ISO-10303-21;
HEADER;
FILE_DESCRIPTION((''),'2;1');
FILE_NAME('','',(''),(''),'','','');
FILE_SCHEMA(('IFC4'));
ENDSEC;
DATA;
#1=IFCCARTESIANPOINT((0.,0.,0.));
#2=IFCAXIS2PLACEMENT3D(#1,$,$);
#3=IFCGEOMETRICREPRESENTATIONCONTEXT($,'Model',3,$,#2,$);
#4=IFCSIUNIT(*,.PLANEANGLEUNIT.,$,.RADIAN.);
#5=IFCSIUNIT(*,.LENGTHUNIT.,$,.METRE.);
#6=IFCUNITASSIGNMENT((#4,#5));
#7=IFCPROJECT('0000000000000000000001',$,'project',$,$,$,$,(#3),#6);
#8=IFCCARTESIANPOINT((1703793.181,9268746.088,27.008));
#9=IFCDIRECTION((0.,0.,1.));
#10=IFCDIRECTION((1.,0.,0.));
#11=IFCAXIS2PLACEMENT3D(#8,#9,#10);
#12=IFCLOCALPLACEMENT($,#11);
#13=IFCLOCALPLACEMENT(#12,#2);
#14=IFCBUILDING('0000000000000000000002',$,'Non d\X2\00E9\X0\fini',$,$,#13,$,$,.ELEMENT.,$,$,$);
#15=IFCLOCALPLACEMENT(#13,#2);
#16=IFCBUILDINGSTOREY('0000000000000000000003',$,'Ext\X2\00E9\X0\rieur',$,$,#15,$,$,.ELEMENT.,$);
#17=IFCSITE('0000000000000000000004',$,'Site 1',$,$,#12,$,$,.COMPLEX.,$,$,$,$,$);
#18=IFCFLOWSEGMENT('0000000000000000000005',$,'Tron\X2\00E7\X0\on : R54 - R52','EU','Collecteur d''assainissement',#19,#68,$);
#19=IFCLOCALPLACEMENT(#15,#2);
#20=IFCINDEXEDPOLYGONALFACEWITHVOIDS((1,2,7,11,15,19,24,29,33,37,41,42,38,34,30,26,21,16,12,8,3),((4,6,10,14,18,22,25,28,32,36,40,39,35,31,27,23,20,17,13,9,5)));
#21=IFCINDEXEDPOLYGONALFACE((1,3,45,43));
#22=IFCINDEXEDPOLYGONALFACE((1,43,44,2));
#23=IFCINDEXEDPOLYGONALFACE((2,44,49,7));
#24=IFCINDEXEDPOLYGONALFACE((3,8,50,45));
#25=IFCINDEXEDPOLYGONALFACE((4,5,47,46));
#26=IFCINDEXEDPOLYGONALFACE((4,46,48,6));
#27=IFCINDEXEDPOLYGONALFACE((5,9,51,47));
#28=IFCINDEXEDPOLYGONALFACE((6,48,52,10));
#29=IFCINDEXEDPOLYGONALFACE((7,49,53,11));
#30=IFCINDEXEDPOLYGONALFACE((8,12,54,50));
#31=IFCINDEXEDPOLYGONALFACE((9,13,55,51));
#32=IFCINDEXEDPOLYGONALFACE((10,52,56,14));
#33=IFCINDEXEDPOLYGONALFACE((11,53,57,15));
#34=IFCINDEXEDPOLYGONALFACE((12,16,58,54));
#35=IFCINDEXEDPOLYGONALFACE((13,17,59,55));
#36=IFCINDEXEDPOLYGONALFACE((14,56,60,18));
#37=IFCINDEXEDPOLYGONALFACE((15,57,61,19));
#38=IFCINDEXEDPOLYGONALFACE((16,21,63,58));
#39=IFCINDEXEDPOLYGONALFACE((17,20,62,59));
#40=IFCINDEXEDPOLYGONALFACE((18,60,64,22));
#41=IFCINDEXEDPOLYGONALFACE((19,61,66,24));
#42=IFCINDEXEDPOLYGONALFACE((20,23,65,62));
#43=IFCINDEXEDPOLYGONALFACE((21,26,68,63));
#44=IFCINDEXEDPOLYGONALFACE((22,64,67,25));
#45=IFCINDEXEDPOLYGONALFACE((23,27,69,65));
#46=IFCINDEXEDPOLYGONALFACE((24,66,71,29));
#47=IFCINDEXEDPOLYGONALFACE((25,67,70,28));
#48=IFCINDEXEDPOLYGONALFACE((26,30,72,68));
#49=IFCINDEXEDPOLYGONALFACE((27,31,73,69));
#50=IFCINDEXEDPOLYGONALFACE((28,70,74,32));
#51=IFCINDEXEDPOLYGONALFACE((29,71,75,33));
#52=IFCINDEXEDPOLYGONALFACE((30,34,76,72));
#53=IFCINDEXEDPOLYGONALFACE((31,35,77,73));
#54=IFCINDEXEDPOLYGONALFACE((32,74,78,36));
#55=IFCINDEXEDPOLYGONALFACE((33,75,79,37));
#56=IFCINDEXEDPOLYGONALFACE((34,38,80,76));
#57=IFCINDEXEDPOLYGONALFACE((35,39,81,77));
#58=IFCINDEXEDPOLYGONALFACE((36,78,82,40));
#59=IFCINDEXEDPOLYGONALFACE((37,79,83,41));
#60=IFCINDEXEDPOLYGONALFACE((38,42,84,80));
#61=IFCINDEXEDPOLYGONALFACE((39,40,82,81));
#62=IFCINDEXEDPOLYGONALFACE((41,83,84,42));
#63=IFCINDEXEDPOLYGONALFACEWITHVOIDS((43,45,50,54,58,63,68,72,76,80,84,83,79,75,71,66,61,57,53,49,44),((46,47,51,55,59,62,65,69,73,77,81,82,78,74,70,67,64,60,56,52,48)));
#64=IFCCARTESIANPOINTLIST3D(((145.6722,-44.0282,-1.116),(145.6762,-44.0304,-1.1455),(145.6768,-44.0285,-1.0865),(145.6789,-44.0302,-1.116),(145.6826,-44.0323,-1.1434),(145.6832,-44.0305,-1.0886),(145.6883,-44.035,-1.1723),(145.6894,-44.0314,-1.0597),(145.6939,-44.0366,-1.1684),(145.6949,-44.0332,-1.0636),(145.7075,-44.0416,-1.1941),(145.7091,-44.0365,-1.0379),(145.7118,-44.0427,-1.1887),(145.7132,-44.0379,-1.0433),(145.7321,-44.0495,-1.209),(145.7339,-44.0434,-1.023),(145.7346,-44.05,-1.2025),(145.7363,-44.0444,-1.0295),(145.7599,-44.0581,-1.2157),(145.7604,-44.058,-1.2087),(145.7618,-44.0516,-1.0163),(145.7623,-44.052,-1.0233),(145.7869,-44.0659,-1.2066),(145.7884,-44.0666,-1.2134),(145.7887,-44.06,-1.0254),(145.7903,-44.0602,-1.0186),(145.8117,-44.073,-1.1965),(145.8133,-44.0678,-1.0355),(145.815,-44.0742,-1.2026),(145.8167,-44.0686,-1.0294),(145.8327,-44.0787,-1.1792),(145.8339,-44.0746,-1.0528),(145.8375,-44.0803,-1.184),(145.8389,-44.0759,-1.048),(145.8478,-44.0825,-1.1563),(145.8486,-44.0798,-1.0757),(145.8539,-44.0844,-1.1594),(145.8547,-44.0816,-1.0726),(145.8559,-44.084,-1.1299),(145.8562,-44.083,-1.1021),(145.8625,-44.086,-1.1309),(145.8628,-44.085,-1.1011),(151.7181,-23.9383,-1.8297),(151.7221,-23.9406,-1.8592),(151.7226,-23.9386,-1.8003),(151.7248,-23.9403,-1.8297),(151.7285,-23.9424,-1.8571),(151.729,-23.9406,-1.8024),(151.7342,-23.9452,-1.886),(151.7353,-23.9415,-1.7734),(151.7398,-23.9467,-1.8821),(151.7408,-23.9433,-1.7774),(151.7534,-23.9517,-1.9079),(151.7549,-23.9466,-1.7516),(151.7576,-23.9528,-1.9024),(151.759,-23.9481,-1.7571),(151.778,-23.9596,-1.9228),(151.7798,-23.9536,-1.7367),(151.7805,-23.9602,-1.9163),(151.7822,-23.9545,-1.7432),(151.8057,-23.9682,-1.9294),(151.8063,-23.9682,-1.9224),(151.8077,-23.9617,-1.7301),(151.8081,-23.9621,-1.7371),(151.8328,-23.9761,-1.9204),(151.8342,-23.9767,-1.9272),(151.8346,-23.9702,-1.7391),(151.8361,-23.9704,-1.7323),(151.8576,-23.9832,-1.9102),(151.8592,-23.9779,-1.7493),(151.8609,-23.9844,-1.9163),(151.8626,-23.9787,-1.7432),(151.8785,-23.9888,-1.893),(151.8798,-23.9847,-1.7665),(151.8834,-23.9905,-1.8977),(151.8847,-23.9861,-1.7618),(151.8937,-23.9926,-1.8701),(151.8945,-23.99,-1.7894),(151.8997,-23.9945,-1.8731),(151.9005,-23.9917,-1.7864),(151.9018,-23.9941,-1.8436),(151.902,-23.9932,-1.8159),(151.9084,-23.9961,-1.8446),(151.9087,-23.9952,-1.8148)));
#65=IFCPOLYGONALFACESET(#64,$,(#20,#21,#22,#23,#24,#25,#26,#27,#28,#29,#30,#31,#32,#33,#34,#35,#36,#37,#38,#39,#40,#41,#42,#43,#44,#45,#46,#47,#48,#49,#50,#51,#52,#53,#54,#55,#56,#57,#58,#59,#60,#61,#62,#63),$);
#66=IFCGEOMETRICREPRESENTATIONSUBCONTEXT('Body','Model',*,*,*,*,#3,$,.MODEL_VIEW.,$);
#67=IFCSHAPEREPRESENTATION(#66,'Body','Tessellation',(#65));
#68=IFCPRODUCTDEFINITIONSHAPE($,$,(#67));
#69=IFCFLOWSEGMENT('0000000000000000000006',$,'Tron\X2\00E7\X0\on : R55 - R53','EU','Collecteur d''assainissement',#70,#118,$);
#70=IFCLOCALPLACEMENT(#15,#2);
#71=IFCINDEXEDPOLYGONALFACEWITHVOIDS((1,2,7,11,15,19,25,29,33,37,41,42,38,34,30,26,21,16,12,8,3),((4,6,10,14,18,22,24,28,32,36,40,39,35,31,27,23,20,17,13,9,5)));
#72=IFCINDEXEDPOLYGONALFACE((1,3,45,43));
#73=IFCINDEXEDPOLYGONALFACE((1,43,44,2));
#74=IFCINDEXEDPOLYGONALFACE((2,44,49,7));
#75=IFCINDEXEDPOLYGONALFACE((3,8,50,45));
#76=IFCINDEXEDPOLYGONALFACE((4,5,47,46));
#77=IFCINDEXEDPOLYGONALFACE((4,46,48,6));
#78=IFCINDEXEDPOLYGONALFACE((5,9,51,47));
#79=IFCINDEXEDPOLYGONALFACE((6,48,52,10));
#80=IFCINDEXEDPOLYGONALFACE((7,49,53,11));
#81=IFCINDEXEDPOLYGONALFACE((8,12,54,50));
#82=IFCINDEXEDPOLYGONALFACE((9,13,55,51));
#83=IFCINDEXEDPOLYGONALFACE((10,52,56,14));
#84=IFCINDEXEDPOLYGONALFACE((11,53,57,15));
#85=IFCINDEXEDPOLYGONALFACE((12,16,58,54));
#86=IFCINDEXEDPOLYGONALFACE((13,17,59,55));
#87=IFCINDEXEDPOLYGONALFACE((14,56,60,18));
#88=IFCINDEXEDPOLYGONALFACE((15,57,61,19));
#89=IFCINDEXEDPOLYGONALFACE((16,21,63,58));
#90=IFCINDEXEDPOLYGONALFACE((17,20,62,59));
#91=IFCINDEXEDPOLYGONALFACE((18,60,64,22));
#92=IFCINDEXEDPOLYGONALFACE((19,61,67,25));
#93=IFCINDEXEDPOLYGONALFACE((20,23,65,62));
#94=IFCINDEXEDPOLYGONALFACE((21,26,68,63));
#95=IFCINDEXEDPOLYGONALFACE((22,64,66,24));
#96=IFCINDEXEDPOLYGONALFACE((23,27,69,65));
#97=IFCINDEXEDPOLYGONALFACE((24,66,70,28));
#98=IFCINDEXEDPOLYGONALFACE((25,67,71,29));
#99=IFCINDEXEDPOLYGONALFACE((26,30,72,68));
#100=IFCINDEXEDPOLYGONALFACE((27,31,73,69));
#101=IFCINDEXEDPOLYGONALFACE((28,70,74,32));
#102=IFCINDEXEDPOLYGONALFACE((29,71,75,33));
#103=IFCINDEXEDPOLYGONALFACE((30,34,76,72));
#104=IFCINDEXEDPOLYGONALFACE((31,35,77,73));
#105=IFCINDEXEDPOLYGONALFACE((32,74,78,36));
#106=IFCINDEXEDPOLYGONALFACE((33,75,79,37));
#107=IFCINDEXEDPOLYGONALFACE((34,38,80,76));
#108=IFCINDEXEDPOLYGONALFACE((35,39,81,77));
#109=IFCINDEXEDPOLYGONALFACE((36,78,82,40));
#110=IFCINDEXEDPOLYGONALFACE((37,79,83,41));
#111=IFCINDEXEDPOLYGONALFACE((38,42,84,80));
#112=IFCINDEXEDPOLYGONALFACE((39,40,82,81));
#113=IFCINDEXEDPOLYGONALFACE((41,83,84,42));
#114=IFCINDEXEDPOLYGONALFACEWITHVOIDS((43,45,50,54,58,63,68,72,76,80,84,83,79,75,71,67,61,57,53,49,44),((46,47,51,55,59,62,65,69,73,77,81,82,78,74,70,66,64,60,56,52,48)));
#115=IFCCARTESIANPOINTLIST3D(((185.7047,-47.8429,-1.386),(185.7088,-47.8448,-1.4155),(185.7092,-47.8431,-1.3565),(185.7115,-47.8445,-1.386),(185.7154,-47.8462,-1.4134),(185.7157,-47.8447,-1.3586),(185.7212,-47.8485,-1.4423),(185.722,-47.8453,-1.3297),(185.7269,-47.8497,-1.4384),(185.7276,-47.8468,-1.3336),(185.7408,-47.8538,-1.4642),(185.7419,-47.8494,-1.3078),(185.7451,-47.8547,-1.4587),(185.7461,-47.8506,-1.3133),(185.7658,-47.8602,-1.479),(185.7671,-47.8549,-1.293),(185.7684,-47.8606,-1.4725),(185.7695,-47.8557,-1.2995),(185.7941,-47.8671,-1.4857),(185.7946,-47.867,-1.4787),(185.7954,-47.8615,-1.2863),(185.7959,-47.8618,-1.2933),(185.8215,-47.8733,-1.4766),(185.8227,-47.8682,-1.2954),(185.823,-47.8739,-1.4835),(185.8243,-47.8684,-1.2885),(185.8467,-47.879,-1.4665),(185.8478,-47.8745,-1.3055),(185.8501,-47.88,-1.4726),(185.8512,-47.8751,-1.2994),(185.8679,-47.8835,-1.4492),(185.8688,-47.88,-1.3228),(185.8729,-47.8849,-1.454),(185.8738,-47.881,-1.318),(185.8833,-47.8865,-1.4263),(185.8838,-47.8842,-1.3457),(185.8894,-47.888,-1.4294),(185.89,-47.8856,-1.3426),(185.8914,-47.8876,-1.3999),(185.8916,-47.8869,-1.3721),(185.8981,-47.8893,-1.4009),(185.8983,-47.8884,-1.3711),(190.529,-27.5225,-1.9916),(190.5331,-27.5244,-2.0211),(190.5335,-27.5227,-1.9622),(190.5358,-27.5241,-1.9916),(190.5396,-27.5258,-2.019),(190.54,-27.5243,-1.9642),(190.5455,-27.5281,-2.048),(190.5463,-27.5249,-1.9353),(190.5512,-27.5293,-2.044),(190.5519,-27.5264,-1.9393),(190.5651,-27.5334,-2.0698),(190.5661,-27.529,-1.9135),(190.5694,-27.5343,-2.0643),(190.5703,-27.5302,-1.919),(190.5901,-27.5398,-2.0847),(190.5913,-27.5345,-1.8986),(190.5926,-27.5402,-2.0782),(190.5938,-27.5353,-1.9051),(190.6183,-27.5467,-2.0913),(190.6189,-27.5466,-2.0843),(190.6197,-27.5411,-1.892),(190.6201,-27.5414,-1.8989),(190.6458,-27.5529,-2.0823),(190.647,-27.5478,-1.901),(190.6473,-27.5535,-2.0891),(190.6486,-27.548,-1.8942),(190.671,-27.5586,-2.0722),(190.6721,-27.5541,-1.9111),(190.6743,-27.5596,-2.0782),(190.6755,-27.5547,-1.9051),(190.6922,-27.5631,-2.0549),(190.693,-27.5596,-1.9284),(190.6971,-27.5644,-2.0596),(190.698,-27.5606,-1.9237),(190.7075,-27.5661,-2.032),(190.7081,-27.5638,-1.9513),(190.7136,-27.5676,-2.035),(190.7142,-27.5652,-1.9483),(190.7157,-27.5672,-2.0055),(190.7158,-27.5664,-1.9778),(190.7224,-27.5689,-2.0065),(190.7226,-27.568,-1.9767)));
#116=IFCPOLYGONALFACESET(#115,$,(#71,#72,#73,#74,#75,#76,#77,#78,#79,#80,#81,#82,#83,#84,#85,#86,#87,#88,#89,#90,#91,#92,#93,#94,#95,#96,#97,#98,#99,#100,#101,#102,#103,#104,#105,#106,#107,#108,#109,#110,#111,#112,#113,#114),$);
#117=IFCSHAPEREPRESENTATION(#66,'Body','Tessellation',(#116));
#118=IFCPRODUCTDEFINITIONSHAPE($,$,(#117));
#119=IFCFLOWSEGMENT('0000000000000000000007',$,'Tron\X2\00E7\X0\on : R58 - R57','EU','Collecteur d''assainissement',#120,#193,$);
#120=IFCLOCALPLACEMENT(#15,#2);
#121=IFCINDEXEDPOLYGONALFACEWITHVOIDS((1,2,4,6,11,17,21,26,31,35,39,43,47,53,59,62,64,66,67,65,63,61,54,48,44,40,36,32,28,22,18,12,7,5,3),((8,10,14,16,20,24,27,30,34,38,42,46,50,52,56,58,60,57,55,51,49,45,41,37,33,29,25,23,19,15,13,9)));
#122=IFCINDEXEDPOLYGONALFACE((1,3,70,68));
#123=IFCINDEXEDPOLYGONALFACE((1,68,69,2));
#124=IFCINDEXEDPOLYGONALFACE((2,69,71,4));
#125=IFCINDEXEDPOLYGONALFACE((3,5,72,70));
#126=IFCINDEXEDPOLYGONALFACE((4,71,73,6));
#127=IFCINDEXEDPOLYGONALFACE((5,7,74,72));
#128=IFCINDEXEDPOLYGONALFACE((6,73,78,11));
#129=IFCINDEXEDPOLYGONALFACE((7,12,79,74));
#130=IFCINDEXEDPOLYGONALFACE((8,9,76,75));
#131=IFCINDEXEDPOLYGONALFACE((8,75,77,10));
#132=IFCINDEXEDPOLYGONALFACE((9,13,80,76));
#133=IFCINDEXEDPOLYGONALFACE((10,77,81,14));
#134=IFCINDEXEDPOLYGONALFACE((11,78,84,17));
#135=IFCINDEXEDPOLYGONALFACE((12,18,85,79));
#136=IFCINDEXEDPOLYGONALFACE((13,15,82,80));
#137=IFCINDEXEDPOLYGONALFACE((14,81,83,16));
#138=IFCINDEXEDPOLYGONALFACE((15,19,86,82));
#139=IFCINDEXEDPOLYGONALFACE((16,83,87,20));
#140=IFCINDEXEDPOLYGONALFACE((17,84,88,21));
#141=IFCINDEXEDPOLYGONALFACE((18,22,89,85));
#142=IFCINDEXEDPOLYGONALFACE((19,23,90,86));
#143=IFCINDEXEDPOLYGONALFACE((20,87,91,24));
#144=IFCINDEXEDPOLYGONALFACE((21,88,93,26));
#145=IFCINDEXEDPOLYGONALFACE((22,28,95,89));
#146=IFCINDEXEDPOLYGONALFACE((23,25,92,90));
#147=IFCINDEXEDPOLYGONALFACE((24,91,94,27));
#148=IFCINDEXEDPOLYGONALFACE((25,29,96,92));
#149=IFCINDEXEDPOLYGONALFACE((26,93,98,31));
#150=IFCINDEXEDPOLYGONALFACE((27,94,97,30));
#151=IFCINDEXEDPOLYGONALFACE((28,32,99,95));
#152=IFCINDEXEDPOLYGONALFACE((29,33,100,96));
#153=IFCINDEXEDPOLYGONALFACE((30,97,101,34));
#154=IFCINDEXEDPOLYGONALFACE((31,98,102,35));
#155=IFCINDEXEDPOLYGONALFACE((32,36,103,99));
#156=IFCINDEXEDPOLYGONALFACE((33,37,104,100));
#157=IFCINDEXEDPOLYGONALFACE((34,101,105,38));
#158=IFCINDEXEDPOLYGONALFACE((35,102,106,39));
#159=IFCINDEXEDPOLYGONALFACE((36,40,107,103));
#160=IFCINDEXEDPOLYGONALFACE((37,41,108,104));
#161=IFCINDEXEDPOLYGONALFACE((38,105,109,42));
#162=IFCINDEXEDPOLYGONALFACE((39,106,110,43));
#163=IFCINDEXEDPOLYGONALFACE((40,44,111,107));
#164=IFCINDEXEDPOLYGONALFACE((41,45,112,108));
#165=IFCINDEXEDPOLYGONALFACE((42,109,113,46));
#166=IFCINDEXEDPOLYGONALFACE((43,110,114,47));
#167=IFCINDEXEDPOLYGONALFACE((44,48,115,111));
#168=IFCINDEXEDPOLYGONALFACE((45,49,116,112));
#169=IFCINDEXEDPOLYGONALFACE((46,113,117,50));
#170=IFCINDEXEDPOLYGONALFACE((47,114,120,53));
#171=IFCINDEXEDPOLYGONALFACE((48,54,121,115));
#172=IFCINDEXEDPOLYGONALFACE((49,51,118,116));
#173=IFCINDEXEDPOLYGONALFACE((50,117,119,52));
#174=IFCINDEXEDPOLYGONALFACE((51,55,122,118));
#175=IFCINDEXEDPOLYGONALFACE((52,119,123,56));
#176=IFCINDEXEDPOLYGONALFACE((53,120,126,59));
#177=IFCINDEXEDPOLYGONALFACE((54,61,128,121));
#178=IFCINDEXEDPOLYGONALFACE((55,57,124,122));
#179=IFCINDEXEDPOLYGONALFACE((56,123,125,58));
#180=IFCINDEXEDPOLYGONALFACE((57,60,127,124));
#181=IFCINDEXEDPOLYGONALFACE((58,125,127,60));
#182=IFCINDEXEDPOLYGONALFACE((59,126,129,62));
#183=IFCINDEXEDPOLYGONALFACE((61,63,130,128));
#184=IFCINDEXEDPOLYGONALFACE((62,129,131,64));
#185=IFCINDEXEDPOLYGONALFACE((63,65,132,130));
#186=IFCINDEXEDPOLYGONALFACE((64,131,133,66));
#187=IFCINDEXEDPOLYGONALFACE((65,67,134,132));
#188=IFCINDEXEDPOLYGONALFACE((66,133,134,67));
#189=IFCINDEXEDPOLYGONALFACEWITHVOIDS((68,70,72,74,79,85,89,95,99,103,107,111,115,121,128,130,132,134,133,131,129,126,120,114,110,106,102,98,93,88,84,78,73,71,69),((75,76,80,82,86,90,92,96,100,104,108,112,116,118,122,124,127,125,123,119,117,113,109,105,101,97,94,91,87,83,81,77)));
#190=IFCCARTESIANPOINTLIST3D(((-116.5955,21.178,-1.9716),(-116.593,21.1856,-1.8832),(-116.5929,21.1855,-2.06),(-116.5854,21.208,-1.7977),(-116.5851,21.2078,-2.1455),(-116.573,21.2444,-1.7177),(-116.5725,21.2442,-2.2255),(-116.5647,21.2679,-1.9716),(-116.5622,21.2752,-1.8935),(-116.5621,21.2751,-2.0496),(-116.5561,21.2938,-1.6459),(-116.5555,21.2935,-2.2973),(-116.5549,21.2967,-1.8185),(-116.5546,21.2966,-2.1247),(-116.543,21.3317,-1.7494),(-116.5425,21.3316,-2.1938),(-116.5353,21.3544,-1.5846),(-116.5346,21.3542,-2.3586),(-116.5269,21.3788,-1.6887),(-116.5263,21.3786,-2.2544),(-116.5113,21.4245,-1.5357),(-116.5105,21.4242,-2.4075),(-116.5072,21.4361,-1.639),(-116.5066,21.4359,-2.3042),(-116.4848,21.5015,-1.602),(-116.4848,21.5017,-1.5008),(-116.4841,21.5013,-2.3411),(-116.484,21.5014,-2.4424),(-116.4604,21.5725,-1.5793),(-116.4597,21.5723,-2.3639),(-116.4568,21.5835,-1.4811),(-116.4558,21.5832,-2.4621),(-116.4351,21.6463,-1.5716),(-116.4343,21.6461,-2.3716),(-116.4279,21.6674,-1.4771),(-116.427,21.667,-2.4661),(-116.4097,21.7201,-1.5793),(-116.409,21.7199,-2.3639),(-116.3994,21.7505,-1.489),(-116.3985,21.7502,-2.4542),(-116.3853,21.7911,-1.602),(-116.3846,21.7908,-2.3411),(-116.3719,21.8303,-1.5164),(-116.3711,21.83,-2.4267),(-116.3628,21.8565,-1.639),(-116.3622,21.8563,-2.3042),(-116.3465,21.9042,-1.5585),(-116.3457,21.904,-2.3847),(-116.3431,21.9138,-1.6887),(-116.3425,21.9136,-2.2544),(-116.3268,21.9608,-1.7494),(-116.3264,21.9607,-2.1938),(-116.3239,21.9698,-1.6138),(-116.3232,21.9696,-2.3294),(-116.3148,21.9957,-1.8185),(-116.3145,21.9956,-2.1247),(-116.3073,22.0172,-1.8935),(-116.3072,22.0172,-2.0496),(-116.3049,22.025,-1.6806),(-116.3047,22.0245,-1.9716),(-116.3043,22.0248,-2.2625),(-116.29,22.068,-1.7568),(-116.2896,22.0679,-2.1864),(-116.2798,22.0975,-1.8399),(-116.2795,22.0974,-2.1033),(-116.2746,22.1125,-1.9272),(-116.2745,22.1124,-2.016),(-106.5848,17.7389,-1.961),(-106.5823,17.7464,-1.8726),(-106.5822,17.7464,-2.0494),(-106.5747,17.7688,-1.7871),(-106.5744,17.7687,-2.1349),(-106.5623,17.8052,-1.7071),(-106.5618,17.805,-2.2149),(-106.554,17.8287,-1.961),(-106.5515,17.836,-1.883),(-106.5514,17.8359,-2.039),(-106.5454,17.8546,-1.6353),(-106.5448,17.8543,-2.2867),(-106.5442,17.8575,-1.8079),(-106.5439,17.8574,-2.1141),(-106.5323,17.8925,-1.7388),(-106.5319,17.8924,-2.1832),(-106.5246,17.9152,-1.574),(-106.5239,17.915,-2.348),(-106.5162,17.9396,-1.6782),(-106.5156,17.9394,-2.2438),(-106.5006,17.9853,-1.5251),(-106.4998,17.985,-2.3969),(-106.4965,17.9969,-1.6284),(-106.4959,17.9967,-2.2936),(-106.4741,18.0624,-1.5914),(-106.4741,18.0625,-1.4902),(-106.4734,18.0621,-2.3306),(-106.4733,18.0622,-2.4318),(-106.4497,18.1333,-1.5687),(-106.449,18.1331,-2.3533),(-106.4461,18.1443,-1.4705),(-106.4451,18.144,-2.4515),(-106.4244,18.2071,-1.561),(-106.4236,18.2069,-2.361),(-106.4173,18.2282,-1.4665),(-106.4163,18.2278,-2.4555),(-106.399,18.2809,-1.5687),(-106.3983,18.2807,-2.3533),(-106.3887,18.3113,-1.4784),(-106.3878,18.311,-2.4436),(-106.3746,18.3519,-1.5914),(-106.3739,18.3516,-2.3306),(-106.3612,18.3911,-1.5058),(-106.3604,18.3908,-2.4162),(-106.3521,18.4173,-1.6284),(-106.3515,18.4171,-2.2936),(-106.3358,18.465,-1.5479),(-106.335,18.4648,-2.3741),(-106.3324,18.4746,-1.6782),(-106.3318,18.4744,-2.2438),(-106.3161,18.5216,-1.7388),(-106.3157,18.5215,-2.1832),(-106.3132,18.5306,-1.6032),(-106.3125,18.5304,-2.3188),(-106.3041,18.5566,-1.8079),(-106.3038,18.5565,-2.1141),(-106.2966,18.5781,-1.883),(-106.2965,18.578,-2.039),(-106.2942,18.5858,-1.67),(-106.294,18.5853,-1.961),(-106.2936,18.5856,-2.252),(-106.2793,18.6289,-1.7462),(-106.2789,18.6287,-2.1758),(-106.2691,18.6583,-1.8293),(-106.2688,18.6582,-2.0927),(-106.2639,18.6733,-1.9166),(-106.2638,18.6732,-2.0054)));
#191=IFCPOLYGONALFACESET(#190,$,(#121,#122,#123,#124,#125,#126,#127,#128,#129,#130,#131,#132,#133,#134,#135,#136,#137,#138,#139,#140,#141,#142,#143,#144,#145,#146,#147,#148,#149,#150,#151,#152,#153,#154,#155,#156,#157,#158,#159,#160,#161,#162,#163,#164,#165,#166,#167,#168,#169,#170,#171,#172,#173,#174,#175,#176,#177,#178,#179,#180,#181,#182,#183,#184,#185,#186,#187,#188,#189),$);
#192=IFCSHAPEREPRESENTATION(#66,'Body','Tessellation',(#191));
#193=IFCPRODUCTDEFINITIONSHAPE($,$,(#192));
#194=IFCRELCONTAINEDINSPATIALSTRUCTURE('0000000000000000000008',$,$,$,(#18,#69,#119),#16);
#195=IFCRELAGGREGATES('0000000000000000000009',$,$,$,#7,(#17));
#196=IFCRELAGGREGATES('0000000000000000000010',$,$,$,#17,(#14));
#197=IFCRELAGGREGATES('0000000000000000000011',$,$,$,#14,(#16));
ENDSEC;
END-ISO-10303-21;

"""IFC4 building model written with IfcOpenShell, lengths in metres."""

from ifc_helpers import new_model, si_unit, frame, origin, origin_2d, place, context, subcontext, project, spatial, hollow_circle, extrude, element, save


model = new_model("IFC4")

# Units and contexts
model_context = context("Model", 3, world=origin())
body_context = subcontext(model_context, "Body", "Model", "MODEL_VIEW")
ifc_project = project(units=[si_unit("PLANEANGLEUNIT", "RADIAN"), si_unit("LENGTHUNIT", "METRE")], contexts=[model_context])

# Site, building, storey
site_placement = place(None, frame((1703793.181, 9268746.088, 27.008), z_axis=(0.0, 0.0, 1.0), x_axis=(1.0, 0.0, 0.0)))
site = spatial("IfcSite", under=ifc_project, at=site_placement, Name="Site 1", CompositionType="COMPLEX")
building_placement = place(site_placement, origin())
building = spatial("IfcBuilding", under=site, at=building_placement, Name="Non défini", CompositionType="ELEMENT")
storey_placement = place(building_placement, origin())
storey = spatial("IfcBuildingStorey", under=building, at=storey_placement, Name="Extérieur", CompositionType="ELEMENT")

# Flow segments
flow_segment_1_placement = place(storey_placement, origin())
element("IfcFlowSegment", 1, at=flow_segment_1_placement, inside=storey, Name="Tronçon : R54 - R52", Description="EU", ObjectType="Collecteur d'assainissement", context=body_context, shape_type="SweptSolid", body=[
    extrude(hollow_circle(Radius=0.1, WallThickness=0.007, at=origin_2d()), frame((145.768, -44.057, -1.116), z_axis=(0.288, 0.957, -0.034), x_axis=(-0.958, 0.288, 0.0)), (0.0, 0.0, 1.0), 20.992),
])
flow_segment_2_placement = place(storey_placement, origin())
element("IfcFlowSegment", 2, at=flow_segment_2_placement, inside=storey, Name="Tronçon : R55 - R53", Description="EU", ObjectType="Collecteur d'assainissement", context=body_context, shape_type="SweptSolid", body=[
    extrude(hollow_circle(Radius=0.1, WallThickness=0.007, at=origin_2d()), frame((185.802, -47.866, -1.386), z_axis=(0.231, 0.973, -0.029), x_axis=(-0.973, 0.231, 0.0)), (0.0, 0.0, 1.0), 20.894),
])
flow_segment_3_placement = place(storey_placement, origin())
element("IfcFlowSegment", 3, at=flow_segment_3_placement, inside=storey, Name="Tronçon : R58 - R57", Description="EU", ObjectType="Collecteur d'assainissement", context=body_context, shape_type="SweptSolid", body=[
    extrude(hollow_circle(Radius=0.495, WallThickness=0.095, at=origin_2d()), frame((-106.424, 18.207, -1.961), z_axis=(-0.946, 0.325, -0.001), x_axis=(-0.325, -0.946, 0.0)), (0.0, 0.0, 1.0), 10.585),
])

save(model, "model.ifc")
